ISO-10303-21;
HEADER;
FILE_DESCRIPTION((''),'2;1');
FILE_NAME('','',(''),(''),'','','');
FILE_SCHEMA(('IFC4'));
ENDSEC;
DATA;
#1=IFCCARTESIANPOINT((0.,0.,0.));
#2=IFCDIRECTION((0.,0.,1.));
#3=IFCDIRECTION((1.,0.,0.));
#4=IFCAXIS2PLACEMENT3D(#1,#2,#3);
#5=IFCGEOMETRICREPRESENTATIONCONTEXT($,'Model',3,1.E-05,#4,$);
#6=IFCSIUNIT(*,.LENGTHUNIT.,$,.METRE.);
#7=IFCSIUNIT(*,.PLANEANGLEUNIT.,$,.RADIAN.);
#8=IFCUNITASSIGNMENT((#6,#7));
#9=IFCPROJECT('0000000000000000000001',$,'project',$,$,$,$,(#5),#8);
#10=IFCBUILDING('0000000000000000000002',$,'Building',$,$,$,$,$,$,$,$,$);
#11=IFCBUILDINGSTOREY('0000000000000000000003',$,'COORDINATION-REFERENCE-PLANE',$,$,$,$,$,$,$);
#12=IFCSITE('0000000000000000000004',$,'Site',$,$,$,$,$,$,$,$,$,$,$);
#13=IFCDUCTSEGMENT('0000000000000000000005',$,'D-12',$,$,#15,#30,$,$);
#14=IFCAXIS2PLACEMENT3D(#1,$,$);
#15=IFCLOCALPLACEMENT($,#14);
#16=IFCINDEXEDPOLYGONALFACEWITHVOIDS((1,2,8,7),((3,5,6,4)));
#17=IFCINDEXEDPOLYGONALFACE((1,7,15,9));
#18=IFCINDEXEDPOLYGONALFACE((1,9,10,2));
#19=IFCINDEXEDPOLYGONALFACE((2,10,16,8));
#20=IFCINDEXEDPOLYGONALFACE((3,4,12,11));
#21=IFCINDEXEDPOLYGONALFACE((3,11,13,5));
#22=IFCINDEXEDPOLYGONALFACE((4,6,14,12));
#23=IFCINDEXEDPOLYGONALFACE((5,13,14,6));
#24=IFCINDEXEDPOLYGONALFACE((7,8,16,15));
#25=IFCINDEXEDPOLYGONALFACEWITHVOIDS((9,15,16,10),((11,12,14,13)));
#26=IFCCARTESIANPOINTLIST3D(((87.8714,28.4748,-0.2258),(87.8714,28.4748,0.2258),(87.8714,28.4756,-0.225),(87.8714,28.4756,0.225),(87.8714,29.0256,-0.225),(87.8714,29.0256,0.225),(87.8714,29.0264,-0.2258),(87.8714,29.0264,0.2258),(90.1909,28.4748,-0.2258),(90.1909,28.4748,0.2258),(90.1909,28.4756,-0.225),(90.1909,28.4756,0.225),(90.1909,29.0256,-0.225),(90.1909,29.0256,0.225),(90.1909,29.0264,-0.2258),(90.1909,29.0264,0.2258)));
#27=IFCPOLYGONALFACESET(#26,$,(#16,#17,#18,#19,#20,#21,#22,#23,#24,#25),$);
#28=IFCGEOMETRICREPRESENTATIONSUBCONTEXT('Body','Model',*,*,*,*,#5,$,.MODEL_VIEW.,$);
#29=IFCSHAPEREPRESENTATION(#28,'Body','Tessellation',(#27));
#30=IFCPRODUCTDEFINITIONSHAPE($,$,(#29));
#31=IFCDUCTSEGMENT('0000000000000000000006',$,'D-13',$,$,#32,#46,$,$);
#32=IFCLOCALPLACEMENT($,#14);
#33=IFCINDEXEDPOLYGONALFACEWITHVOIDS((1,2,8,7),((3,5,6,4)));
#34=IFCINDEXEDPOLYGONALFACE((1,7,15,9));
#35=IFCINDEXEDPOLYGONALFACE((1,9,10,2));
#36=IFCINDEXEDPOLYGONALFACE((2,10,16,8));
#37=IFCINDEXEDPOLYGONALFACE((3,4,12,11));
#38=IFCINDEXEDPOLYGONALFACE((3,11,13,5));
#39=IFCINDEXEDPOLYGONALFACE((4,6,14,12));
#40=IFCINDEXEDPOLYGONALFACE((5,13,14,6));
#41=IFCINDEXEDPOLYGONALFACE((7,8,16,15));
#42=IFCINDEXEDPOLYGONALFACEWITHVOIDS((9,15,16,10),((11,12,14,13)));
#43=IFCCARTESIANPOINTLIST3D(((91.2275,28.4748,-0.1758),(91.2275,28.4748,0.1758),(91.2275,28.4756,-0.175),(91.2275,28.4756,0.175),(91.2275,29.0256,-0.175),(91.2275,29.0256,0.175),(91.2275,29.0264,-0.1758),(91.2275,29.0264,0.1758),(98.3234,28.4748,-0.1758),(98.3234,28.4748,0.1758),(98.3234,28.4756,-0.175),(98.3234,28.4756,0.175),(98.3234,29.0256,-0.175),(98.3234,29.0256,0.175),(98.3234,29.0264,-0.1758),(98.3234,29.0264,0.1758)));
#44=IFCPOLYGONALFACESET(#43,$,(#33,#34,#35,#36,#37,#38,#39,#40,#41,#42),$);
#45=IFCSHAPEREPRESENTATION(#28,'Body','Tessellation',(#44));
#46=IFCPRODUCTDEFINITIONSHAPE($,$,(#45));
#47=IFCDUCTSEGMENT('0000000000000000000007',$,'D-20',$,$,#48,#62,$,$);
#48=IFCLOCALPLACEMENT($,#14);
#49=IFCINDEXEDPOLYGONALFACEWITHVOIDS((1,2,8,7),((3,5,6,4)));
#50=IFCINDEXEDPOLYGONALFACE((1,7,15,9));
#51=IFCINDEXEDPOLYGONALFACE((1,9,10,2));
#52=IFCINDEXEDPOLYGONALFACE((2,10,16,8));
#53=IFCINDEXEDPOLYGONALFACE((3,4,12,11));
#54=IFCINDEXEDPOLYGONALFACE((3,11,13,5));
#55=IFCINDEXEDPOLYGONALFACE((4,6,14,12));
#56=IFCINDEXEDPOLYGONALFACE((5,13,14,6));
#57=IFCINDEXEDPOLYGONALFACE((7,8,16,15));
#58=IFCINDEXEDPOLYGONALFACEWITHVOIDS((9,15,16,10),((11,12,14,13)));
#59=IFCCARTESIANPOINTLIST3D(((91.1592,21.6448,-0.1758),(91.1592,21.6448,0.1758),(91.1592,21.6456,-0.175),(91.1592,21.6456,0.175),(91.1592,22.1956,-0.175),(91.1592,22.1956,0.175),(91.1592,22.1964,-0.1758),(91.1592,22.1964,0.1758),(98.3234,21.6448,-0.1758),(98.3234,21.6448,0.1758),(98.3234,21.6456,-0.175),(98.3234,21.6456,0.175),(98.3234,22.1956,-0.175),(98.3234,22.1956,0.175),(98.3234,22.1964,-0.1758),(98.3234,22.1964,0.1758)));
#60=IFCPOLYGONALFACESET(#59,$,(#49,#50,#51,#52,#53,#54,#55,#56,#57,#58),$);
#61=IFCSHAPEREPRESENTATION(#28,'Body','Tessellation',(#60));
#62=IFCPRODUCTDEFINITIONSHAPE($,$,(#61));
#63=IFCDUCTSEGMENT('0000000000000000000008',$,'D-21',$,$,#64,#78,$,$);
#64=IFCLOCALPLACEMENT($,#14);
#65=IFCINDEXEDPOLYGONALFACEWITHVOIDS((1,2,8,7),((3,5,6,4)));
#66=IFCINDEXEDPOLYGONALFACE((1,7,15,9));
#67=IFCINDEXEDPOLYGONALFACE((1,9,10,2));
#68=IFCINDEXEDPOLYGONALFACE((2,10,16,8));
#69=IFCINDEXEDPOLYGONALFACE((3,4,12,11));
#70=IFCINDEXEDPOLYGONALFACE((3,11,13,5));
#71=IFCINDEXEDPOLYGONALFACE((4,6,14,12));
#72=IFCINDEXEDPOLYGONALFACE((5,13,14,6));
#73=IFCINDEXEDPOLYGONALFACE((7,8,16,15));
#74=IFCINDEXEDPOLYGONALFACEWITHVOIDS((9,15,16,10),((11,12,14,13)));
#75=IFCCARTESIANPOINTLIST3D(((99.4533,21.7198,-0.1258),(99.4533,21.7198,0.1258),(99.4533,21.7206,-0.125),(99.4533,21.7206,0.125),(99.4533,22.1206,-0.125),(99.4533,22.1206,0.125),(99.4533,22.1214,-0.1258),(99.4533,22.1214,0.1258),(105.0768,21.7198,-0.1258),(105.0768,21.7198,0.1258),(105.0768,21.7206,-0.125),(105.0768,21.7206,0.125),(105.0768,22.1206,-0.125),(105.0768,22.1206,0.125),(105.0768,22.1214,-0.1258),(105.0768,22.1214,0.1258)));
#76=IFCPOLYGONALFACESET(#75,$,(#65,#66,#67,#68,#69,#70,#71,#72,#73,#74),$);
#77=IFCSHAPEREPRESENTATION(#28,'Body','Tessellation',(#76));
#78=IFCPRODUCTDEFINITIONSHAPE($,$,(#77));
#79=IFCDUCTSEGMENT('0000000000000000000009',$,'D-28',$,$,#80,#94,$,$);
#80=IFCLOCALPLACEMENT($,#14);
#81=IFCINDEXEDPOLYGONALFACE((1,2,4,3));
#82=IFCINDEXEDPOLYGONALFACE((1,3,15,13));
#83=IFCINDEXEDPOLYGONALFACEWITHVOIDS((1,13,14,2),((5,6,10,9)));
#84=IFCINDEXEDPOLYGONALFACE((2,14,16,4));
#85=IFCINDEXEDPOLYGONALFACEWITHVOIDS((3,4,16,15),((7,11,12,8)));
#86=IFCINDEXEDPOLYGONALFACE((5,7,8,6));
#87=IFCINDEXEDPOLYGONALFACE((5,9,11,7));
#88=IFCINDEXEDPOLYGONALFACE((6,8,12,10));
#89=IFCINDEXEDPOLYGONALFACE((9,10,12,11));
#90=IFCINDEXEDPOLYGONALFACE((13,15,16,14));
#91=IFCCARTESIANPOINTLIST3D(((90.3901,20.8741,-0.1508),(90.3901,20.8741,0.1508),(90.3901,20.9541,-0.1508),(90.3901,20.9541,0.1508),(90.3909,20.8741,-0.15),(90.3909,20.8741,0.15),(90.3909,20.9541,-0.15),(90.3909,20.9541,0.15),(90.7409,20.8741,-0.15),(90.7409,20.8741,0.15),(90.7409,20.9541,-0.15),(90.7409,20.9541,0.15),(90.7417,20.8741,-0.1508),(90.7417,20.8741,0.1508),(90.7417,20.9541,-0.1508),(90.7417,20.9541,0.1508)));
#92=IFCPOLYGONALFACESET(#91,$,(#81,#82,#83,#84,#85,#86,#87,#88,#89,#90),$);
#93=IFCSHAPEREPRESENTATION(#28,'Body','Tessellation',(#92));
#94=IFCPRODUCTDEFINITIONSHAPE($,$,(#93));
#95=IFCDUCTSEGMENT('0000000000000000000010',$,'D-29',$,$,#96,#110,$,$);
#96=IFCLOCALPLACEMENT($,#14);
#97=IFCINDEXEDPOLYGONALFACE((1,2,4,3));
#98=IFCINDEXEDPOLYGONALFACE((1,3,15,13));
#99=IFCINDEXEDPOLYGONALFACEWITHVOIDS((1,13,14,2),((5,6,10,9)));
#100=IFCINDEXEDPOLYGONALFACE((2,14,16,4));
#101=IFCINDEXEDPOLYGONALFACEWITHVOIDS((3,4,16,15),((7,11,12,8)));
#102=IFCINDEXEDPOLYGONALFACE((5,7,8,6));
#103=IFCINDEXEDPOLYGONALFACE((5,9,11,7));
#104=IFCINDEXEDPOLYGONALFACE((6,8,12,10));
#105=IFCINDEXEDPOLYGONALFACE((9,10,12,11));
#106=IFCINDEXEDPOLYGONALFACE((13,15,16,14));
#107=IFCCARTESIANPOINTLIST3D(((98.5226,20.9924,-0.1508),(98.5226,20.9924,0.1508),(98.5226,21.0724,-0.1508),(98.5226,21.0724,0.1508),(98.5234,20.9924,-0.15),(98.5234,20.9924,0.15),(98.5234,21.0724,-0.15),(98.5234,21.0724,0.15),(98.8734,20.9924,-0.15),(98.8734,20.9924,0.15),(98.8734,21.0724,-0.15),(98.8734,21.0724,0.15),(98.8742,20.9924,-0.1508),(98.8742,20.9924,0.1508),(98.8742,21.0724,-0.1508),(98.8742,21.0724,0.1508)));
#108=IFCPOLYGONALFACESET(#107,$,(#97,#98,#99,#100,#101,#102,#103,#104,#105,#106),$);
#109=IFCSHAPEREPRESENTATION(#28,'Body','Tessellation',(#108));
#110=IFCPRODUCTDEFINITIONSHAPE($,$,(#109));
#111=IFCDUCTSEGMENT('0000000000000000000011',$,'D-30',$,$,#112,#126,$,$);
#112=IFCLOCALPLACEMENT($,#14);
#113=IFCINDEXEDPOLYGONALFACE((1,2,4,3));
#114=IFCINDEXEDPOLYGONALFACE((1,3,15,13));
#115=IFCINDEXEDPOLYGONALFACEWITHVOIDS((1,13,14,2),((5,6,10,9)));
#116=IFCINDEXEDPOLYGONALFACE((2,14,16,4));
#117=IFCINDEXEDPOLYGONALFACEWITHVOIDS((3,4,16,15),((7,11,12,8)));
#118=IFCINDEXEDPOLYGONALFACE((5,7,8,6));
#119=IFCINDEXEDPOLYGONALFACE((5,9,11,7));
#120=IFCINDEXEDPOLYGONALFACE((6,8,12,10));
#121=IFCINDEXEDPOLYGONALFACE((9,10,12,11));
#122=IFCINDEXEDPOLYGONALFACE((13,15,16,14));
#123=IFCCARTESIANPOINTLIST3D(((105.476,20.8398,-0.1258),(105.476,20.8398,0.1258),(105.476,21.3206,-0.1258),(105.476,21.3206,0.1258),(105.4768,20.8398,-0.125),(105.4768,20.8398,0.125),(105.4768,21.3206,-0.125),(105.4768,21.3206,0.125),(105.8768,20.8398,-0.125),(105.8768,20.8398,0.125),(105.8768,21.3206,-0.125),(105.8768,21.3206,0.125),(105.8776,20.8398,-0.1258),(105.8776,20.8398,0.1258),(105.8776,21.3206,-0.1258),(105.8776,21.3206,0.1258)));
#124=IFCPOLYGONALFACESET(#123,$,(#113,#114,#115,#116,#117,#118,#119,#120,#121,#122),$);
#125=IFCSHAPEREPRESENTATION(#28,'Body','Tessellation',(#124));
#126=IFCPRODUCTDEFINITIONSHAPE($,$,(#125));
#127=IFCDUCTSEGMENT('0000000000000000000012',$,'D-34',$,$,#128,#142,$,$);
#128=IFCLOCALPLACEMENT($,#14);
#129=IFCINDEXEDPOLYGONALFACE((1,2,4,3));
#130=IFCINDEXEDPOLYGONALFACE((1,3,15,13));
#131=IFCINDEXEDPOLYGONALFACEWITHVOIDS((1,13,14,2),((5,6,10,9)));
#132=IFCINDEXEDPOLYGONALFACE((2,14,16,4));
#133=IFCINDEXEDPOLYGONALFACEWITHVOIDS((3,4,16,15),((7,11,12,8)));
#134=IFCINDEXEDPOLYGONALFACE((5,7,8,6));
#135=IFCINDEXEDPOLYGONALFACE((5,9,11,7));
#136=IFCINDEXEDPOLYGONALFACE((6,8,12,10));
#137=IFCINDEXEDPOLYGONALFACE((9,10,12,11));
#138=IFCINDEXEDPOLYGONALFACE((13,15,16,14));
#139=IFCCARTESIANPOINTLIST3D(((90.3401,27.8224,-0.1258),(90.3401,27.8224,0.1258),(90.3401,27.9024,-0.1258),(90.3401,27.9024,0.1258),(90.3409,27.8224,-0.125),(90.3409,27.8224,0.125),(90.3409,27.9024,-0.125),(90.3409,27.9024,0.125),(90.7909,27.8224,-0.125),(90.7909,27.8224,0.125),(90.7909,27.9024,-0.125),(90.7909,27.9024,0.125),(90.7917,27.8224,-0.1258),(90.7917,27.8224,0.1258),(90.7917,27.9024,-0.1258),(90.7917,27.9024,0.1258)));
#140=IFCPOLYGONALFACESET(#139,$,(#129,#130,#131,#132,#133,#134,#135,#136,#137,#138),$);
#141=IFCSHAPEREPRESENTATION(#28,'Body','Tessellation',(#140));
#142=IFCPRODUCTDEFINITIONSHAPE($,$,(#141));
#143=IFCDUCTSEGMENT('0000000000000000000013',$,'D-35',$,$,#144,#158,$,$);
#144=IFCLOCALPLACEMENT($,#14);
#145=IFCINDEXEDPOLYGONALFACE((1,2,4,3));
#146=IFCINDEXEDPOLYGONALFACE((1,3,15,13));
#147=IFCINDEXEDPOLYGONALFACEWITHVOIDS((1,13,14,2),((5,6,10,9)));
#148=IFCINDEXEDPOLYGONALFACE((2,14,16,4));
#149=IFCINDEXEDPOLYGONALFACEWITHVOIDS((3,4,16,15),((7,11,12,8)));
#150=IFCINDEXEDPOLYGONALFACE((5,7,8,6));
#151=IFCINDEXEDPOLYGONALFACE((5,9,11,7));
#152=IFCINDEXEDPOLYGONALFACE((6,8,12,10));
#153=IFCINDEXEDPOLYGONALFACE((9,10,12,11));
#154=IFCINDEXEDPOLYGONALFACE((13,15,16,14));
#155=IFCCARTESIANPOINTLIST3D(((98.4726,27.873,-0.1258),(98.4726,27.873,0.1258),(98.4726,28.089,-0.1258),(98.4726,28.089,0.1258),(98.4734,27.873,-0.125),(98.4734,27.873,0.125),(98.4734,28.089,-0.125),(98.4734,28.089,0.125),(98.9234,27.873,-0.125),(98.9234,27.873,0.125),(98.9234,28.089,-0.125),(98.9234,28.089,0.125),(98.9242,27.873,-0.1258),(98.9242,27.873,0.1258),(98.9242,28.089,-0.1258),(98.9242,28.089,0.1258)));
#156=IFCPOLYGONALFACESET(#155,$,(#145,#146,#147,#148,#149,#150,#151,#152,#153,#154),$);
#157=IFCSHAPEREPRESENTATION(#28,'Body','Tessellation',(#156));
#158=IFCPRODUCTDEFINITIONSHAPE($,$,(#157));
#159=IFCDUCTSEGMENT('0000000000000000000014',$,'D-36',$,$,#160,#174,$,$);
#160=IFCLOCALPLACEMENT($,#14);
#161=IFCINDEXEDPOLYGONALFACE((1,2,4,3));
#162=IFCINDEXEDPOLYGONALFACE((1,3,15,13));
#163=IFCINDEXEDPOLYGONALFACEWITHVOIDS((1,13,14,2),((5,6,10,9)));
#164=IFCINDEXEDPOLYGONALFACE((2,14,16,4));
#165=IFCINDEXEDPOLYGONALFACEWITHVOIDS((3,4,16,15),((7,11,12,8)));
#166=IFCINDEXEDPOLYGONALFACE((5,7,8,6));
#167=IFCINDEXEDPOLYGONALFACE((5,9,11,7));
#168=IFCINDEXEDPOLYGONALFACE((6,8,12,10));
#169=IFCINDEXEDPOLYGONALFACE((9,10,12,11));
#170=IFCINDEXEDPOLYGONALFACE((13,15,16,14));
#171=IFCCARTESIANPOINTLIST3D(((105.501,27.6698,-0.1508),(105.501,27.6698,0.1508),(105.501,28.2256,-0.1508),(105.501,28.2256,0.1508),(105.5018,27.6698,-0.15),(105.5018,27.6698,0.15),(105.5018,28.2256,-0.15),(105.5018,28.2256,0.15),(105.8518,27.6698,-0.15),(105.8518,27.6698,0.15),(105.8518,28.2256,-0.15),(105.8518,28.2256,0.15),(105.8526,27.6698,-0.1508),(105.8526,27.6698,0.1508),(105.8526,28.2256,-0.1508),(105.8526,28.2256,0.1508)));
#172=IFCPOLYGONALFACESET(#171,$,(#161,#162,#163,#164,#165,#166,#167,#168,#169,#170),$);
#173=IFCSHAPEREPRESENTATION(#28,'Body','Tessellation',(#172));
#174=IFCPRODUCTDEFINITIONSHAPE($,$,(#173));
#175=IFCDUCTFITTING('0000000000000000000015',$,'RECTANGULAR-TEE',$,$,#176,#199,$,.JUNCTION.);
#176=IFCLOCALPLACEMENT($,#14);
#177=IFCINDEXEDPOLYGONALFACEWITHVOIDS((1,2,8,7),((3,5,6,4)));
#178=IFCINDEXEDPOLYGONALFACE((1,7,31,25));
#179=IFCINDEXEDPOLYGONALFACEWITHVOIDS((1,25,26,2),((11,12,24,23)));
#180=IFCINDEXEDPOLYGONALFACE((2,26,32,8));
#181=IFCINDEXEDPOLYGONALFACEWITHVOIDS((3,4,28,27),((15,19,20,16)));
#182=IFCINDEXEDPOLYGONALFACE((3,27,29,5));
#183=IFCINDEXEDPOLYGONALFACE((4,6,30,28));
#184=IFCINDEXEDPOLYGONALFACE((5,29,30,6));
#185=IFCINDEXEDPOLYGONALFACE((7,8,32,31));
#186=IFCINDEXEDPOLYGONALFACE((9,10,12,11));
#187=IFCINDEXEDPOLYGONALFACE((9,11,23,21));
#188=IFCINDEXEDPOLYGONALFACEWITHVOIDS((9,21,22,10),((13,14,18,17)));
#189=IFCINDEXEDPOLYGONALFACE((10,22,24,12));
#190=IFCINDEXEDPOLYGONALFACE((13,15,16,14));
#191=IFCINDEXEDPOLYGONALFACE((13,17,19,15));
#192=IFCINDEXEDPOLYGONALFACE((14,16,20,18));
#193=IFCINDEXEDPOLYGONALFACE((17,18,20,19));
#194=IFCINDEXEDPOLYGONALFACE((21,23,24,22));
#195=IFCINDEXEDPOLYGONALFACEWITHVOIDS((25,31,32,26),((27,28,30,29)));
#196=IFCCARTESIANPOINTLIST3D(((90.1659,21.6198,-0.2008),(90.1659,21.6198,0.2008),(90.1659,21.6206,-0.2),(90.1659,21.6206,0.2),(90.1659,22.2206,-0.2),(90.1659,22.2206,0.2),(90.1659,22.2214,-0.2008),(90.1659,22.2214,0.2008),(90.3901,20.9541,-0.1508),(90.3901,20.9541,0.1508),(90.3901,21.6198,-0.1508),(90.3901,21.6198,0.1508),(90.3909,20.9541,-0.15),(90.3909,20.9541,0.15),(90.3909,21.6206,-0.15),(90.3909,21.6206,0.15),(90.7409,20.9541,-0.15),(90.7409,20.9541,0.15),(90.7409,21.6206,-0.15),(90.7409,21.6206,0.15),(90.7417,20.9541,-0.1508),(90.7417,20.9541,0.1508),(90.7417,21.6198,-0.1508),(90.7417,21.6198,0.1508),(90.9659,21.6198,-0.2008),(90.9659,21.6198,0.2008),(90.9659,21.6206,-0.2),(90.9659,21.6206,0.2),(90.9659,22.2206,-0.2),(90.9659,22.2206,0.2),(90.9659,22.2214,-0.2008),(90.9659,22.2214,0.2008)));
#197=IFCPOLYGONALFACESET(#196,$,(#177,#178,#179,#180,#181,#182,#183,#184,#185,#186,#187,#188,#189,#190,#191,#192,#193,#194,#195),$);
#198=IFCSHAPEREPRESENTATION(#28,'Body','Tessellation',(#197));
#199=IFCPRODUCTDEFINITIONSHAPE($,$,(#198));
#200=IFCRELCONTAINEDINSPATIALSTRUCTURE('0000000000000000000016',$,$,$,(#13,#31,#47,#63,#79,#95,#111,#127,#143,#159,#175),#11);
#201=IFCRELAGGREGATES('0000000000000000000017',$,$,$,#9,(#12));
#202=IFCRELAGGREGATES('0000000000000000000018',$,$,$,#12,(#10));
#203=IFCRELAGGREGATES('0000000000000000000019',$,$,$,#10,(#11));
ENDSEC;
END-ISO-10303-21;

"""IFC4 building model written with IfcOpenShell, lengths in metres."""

from ifc_helpers import new_model, si_unit, frame, origin, origin_with_axes, place, context, subcontext, project, spatial, rectangle, hollow_rectangle, extrude, boolean, element, save


model = new_model("IFC4")

# Units and contexts
model_context = context("Model", 3, precision=1e-05, world=origin_with_axes())
body_context_1 = subcontext(model_context, "Body", "Model", "MODEL_VIEW")
ifc_project = project(units=[si_unit("LENGTHUNIT", "METRE"), si_unit("PLANEANGLEUNIT", "RADIAN")], contexts=[model_context])

# Site, building, storey
site = spatial("IfcSite", under=ifc_project, Name="Site")
building = spatial("IfcBuilding", under=site, Name="Building")
storey = spatial("IfcBuildingStorey", under=building, Name="COORDINATION-REFERENCE-PLANE")

# Duct segments
duct_segment_1_placement = place(None, frame((87.8714, 28.7506, 0.0), z_axis=(1.0, 0.0, 0.0), x_axis=(0.0, 1.0, 0.0)))
element("IfcDuctSegment", 1, at=duct_segment_1_placement, inside=storey, Name="D-12", context=body_context_1, shape_type="SweptSolid", body=[
    extrude(hollow_rectangle(XDim=0.5516, YDim=0.4516, WallThickness=0.0008), origin(), (0.0, 0.0, 1.0), 2.3195),
])
duct_segment_2_placement = place(None, frame((91.2275, 28.7506, 0.0), z_axis=(1.0, 0.0, 0.0), x_axis=(0.0, 1.0, 0.0)))
element("IfcDuctSegment", 2, at=duct_segment_2_placement, inside=storey, Name="D-13", context=body_context_1, shape_type="SweptSolid", body=[
    extrude(hollow_rectangle(XDim=0.5516, YDim=0.3516, WallThickness=0.0008), origin(), (0.0, 0.0, 1.0), 7.0959),
])
duct_segment_3_placement = place(None, frame((91.1592, 21.9206, 0.0), z_axis=(1.0, 0.0, 0.0), x_axis=(0.0, 1.0, 0.0)))
element("IfcDuctSegment", 3, at=duct_segment_3_placement, inside=storey, Name="D-20", context=body_context_1, shape_type="SweptSolid", body=[
    extrude(hollow_rectangle(XDim=0.5516, YDim=0.3516, WallThickness=0.0008), origin(), (0.0, 0.0, 1.0), 7.1642),
])
duct_segment_4_placement = place(None, frame((99.4533, 21.9206, 0.0), z_axis=(1.0, 0.0, 0.0), x_axis=(0.0, 1.0, 0.0)))
element("IfcDuctSegment", 4, at=duct_segment_4_placement, inside=storey, Name="D-21", context=body_context_1, shape_type="SweptSolid", body=[
    extrude(hollow_rectangle(XDim=0.4016, YDim=0.2516, WallThickness=0.0008), origin(), (0.0, 0.0, 1.0), 5.6234),
])
for number, where, z_axis, x_axis, name in (
    (5, (90.5659, 20.8741, 0.0), (0.0, 1.0, 0.0), (1.0, 0.0, 0.0), "D-28"),
    (6, (98.6984, 20.9924, 0.0), (0.0, 1.0, 0.0), (1.0, 0.0, 0.0), "D-29"),
):
    element("IfcDuctSegment", number, at=place(None, frame(where, z_axis=z_axis, x_axis=x_axis)), inside=storey, Name=name, context=body_context_1, shape_type="SweptSolid", body=[
        extrude(hollow_rectangle(XDim=0.3516, YDim=0.3016, WallThickness=0.0008), origin(), (0.0, 0.0, 1.0), 0.08),
    ])
duct_segment_5_placement = place(None, frame((105.6768, 20.8398, 0.0), z_axis=(0.0, 1.0, 0.0), x_axis=(1.0, 0.0, 0.0)))
element("IfcDuctSegment", 7, at=duct_segment_5_placement, inside=storey, Name="D-30", context=body_context_1, shape_type="SweptSolid", body=[
    extrude(hollow_rectangle(XDim=0.4016, YDim=0.2516, WallThickness=0.0008), origin(), (0.0, 0.0, 1.0), 0.4808),
])
duct_segment_6_placement = place(None, frame((90.5659, 27.8224, 0.0), z_axis=(0.0, 1.0, 0.0), x_axis=(1.0, 0.0, 0.0)))
element("IfcDuctSegment", 8, at=duct_segment_6_placement, inside=storey, Name="D-34", context=body_context_1, shape_type="SweptSolid", body=[
    extrude(hollow_rectangle(XDim=0.4516, YDim=0.2516, WallThickness=0.0008), origin(), (0.0, 0.0, 1.0), 0.08),
])
duct_segment_7_placement = place(None, frame((98.6984, 27.873, 0.0), z_axis=(0.0, 1.0, 0.0), x_axis=(1.0, 0.0, 0.0)))
element("IfcDuctSegment", 9, at=duct_segment_7_placement, inside=storey, Name="D-35", context=body_context_1, shape_type="SweptSolid", body=[
    extrude(hollow_rectangle(XDim=0.4516, YDim=0.2516, WallThickness=0.0008), origin(), (0.0, 0.0, 1.0), 0.216),
])
duct_segment_8_placement = place(None, frame((105.6768, 27.6698, 0.0), z_axis=(0.0, 1.0, 0.0), x_axis=(1.0, 0.0, 0.0)))
element("IfcDuctSegment", 10, at=duct_segment_8_placement, inside=storey, Name="D-36", context=body_context_1, shape_type="SweptSolid", body=[
    extrude(hollow_rectangle(XDim=0.3516, YDim=0.3016, WallThickness=0.0008), origin(), (0.0, 0.0, 1.0), 0.5558),
])

# Duct fitting
duct_fitting_1_placement = place(None, frame((90.5659, 21.9206, 0.0), z_axis=(1.0, 0.0, 0.0), x_axis=(0.0, -1.0, 0.0)))
solid_1 = boolean("UNION", extrude(rectangle(XDim=0.6, YDim=0.4), frame((0.0, 0.0, -0.4), z_axis=(0.0, 0.0, 1.0), x_axis=(1.0, 0.0, 0.0)), (0.0, 0.0, 1.0), 0.8), extrude(rectangle(XDim=0.35, YDim=0.3), frame((0.0, 0.0, 0.0), z_axis=(1.0, 0.0, 0.0), x_axis=(0.0, 0.0, -1.0)), (0.0, 0.0, 1.0), 0.9665))
element("IfcDuctFitting", 11, at=duct_fitting_1_placement, inside=storey, Name="RECTANGULAR-TEE", PredefinedType="JUNCTION", context=body_context_1, shape_type="CSG", body=[
    boolean("DIFFERENCE", boolean("UNION", extrude(rectangle(XDim=0.6016, YDim=0.4016), frame((0.0, 0.0, -0.4), z_axis=(0.0, 0.0, 1.0), x_axis=(1.0, 0.0, 0.0)), (0.0, 0.0, 1.0), 0.8), extrude(rectangle(XDim=0.3516, YDim=0.3016), frame((0.0, 0.0, 0.0), z_axis=(1.0, 0.0, 0.0), x_axis=(0.0, 0.0, -1.0)), (0.0, 0.0, 1.0), 0.9665)), solid_1),
])

save(model, "model.ifc")
